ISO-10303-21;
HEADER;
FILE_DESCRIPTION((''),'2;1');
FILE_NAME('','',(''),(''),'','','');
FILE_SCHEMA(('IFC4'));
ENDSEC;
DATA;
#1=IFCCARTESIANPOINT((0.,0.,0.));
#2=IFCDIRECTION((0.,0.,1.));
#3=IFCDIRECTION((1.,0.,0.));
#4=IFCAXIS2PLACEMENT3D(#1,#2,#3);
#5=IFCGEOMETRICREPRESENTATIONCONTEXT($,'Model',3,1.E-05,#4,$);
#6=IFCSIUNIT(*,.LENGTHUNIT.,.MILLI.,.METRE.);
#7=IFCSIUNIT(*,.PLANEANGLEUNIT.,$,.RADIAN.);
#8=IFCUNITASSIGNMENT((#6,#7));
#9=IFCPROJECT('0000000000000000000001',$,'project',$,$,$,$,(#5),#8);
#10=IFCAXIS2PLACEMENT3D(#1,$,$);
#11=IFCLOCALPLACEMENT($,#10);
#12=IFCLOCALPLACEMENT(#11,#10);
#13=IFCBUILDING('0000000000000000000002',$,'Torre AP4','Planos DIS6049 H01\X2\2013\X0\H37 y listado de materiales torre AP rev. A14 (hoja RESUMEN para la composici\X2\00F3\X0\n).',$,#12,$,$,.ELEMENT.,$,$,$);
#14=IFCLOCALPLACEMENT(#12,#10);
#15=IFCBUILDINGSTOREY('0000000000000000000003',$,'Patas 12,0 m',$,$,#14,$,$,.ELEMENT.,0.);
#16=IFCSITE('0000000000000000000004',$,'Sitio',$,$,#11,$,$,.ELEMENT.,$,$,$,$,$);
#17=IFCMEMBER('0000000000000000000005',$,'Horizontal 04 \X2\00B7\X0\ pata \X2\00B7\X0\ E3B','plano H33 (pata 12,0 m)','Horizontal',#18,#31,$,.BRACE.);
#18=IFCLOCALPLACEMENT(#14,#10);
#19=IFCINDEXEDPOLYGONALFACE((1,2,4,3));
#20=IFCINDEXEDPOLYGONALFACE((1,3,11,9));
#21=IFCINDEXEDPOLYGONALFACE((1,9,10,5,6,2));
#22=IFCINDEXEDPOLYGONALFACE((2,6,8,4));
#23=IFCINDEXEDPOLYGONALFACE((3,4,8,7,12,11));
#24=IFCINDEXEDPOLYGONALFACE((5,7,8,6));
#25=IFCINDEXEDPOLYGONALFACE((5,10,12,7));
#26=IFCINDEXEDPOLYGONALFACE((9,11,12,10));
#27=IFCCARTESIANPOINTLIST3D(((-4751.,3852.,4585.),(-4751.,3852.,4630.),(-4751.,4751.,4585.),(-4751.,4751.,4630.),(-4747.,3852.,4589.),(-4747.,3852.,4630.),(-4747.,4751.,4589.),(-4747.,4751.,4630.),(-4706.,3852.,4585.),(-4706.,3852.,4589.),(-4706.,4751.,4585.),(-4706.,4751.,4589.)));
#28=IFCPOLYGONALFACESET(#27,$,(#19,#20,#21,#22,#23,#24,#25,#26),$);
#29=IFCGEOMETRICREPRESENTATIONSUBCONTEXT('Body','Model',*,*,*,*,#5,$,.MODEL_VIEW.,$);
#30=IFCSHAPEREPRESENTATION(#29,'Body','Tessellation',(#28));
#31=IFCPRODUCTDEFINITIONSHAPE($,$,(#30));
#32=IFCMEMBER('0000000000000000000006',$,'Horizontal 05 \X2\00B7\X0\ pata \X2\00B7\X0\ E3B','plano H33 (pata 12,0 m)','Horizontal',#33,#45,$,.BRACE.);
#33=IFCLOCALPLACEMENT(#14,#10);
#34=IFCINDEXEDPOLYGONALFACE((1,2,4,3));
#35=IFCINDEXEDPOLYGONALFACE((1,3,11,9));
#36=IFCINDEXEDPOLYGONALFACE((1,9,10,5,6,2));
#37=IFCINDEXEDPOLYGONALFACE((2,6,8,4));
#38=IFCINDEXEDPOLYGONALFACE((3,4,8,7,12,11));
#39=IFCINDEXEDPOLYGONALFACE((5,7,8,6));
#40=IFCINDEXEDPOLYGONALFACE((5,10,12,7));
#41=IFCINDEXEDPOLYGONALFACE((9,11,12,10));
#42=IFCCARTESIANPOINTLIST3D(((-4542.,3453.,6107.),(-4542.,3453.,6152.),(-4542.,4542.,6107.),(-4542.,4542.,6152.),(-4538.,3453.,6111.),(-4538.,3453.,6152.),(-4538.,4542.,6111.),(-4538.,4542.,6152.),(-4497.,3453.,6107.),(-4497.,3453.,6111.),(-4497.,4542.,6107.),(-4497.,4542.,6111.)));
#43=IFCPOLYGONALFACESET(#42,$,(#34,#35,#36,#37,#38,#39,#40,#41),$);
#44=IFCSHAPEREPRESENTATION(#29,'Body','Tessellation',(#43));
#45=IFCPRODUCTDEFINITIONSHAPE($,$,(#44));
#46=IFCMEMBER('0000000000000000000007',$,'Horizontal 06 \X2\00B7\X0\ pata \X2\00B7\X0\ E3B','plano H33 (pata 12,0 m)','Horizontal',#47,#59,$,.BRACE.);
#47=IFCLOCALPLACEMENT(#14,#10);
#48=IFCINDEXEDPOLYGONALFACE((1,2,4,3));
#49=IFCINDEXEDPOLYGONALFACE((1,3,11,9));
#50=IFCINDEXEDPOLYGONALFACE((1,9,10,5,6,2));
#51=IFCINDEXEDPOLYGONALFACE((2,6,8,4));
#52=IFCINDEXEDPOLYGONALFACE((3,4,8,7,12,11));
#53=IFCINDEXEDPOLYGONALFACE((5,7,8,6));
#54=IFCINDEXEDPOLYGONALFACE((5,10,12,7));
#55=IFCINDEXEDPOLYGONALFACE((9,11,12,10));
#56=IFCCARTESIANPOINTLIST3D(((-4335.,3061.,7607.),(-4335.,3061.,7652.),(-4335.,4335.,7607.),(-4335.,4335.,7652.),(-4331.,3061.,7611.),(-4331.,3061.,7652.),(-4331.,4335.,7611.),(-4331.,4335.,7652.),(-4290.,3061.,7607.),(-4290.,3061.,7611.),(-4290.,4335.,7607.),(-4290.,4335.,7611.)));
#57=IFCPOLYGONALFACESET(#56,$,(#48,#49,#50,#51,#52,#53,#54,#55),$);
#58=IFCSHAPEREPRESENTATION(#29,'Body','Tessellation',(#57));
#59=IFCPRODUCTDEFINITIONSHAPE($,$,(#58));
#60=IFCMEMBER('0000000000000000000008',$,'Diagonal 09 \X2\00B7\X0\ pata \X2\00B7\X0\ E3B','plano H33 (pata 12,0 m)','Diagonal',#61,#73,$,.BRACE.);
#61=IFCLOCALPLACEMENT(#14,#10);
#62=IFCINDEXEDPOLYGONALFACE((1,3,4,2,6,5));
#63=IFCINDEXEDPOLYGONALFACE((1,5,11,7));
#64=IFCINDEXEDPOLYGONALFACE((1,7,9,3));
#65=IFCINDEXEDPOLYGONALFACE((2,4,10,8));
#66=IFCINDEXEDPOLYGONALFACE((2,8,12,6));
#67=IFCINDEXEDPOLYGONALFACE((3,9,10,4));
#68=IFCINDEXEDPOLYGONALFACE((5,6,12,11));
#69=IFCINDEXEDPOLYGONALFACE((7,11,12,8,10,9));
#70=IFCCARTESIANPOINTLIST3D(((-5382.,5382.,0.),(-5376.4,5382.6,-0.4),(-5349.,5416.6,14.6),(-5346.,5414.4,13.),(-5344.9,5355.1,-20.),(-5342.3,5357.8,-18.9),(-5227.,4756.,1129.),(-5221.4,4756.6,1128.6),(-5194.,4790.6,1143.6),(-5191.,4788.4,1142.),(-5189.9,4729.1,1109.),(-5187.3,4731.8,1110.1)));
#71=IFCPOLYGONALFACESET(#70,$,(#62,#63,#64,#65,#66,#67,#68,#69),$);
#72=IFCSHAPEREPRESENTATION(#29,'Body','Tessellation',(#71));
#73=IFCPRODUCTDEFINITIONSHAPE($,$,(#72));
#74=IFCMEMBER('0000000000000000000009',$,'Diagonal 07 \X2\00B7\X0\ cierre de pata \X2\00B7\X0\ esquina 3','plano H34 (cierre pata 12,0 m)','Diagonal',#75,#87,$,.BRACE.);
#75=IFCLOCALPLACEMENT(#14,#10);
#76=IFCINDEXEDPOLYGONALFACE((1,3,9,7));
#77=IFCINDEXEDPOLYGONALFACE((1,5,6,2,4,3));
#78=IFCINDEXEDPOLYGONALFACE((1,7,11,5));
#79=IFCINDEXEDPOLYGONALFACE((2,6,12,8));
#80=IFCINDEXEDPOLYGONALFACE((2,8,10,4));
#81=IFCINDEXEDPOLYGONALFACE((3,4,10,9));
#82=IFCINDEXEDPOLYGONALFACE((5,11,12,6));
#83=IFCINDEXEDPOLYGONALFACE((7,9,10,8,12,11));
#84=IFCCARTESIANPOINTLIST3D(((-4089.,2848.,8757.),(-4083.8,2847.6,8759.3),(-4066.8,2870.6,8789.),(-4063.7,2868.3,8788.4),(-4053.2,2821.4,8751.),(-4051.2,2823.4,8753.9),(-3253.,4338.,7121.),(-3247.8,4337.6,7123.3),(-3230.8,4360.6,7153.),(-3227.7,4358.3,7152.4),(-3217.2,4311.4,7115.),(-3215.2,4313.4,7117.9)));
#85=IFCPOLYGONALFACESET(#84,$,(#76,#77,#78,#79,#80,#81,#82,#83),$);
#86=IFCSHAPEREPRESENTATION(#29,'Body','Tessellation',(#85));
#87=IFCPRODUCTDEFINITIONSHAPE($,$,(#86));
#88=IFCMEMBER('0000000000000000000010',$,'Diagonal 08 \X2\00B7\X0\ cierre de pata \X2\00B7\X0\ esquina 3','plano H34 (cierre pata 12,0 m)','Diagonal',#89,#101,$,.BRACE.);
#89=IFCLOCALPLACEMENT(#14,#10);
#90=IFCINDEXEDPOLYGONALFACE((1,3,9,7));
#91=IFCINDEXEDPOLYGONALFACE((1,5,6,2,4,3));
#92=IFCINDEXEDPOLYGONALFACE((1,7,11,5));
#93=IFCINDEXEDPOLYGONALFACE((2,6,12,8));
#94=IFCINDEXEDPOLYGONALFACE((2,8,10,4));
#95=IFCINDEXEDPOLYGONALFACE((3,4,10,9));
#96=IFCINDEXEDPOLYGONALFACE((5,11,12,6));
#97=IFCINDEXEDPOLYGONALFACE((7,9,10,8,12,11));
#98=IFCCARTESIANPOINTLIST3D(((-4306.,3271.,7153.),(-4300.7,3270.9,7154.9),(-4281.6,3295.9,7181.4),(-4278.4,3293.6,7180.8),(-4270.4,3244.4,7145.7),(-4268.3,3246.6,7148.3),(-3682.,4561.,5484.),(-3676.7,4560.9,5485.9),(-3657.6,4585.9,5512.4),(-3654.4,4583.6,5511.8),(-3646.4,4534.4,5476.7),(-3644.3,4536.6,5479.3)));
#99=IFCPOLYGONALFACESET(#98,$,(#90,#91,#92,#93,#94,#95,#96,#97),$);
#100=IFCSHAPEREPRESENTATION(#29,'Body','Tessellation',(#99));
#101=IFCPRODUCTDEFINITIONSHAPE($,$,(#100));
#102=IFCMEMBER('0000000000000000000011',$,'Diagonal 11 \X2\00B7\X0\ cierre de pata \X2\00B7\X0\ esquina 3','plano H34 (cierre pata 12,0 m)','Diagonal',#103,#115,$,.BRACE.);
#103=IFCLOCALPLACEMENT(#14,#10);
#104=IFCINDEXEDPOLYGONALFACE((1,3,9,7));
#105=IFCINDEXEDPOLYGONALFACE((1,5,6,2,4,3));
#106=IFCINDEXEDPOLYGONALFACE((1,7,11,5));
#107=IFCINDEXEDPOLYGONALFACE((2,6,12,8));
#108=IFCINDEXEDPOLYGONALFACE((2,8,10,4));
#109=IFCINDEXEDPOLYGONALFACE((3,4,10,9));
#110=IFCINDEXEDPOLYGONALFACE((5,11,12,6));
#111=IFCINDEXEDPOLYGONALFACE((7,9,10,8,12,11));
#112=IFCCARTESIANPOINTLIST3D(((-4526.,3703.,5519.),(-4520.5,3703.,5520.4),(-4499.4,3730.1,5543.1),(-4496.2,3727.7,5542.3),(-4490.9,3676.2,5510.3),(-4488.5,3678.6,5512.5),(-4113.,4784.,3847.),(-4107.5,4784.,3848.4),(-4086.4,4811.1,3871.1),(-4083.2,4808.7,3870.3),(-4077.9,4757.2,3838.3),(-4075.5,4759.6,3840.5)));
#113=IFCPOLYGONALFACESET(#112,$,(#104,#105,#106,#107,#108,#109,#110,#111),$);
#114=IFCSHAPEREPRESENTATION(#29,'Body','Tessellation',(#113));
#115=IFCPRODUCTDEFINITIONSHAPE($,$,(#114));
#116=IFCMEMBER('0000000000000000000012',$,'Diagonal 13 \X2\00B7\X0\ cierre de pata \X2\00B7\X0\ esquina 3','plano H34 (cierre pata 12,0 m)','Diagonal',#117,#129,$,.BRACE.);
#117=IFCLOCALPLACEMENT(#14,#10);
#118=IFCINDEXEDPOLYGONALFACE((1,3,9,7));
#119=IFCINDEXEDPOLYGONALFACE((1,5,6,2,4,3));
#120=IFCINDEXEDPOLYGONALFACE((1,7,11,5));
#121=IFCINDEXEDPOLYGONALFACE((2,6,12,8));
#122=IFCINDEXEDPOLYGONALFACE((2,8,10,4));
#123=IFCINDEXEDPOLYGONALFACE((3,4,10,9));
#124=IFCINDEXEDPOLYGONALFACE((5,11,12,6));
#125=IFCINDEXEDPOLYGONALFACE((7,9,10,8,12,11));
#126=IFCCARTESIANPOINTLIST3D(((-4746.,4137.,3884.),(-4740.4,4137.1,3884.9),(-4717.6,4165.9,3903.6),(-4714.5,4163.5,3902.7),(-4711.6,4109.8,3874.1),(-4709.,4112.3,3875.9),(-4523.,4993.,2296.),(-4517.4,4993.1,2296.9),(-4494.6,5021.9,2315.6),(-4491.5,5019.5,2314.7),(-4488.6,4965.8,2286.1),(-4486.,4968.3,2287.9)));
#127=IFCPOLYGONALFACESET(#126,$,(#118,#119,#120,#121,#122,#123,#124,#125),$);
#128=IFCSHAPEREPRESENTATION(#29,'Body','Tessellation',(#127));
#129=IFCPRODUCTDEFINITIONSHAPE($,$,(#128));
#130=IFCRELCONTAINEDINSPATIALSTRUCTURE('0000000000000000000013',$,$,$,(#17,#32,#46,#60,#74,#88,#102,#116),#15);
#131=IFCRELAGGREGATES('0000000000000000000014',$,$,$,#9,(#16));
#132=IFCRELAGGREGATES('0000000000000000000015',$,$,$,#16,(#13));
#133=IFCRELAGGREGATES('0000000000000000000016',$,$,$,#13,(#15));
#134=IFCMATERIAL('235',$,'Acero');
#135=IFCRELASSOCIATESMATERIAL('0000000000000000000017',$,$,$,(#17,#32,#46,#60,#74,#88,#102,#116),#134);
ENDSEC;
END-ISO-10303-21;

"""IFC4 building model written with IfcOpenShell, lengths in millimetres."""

from ifc_helpers import new_model, si_unit, frame, frame_2d, origin, origin_with_axes, place, context, subcontext, project, spatial, l_section, extrude, material, element, save


model = new_model("IFC4")

# Units and contexts
model_context = context("Model", 3, precision=1e-05, world=origin_with_axes())
body_context = subcontext(model_context, "Body", "Model", "MODEL_VIEW")
ifc_project = project(units=[si_unit("LENGTHUNIT", "METRE", prefix="MILLI"), si_unit("PLANEANGLEUNIT", "RADIAN")], contexts=[model_context])

# Site, building, storey
site_placement = place(None, origin())
site = spatial("IfcSite", under=ifc_project, at=site_placement, Name="Sitio", CompositionType="ELEMENT")
building_placement = place(site_placement, origin())
building = spatial("IfcBuilding", under=site, at=building_placement, Name="Torre AP4", Description="Planos DIS6049 H01–H37 y listado de materiales torre AP rev. A14 (hoja RESUMEN para la composición).", CompositionType="ELEMENT")
storey_placement = place(building_placement, origin())
storey = spatial("IfcBuildingStorey", under=building, at=storey_placement, Name="Patas 12,0 m", CompositionType="ELEMENT", Elevation=0.0)

# Members
ifc_material_1 = material(Name="235", Category="Acero")
member_1_placement = place(storey_placement, frame((-4751.0, 4751.0, 4585.0), z_axis=(0.0, -1.0, 0.0), x_axis=(1.0, 0.0, 0.0)))
element("IfcMember", 1, at=member_1_placement, inside=storey, material=ifc_material_1, Name="Horizontal 04 · pata · E3B", Description="plano H33 (pata 12,0 m)", ObjectType="Horizontal", PredefinedType="BRACE", context=body_context, shape_type="SweptSolid", body=[
    extrude(l_section(Depth=45.0, Width=45.0, Thickness=4.0, at=frame_2d((22.5, 22.5))), None, (0.0, 0.0, 1.0), 899.0),
])
member_2_placement = place(storey_placement, frame((-4542.0, 4542.0, 6107.0), z_axis=(0.0, -1.0, 0.0), x_axis=(1.0, 0.0, 0.0)))
element("IfcMember", 2, at=member_2_placement, inside=storey, material=ifc_material_1, Name="Horizontal 05 · pata · E3B", Description="plano H33 (pata 12,0 m)", ObjectType="Horizontal", PredefinedType="BRACE", context=body_context, shape_type="SweptSolid", body=[
    extrude(l_section(Depth=45.0, Width=45.0, Thickness=4.0, at=frame_2d((22.5, 22.5))), None, (0.0, 0.0, 1.0), 1089.0),
])
member_3_placement = place(storey_placement, frame((-4335.0, 4335.0, 7607.0), z_axis=(0.0, -1.0, 0.0), x_axis=(1.0, 0.0, 0.0)))
element("IfcMember", 3, at=member_3_placement, inside=storey, material=ifc_material_1, Name="Horizontal 06 · pata · E3B", Description="plano H33 (pata 12,0 m)", ObjectType="Horizontal", PredefinedType="BRACE", context=body_context, shape_type="SweptSolid", body=[
    extrude(l_section(Depth=45.0, Width=45.0, Thickness=4.0, at=frame_2d((22.5, 22.5))), None, (0.0, 0.0, 1.0), 1274.0),
])
member_4_placement = place(storey_placement, frame((-5382.0, 5382.0, 0.0), z_axis=(0.119212, -0.481461, 0.868322), x_axis=(0.741182, -0.53876, -0.400484)))
element("IfcMember", 4, at=member_4_placement, inside=storey, material=ifc_material_1, Name="Diagonal 09 · pata · E3B", Description="plano H33 (pata 12,0 m)", ObjectType="Diagonal", PredefinedType="BRACE", context=body_context, shape_type="SweptSolid", body=[
    extrude(l_section(Depth=50.0, Width=50.0, Thickness=4.0, at=frame_2d((25.0, 25.0))), None, (0.0, 0.0, 1.0), 1300.2),
])
member_5_placement = place(storey_placement, frame((-3253.0, 4338.0, 7121.0), z_axis=(-0.353417, -0.629894, 0.691615), x_axis=(0.795293, -0.591591, -0.1324)))
element("IfcMember", 5, at=member_5_placement, inside=storey, material=ifc_material_1, Name="Diagonal 07 · cierre de pata · esquina 3", Description="plano H34 (cierre pata 12,0 m)", ObjectType="Diagonal", PredefinedType="BRACE", context=body_context, shape_type="SweptSolid", body=[
    extrude(l_section(Depth=45.0, Width=45.0, Thickness=4.0, at=frame_2d((22.5, 22.5))), None, (0.0, 0.0, 1.0), 2365.5),
])
member_6_placement = place(storey_placement, frame((-3682.0, 4561.0, 5484.0), z_axis=(-0.283665, -0.586422, 0.758712), x_axis=(0.790335, -0.591049, -0.161345)))
element("IfcMember", 6, at=member_6_placement, inside=storey, material=ifc_material_1, Name="Diagonal 08 · cierre de pata · esquina 3", Description="plano H34 (cierre pata 12,0 m)", ObjectType="Diagonal", PredefinedType="BRACE", context=body_context, shape_type="SweptSolid", body=[
    extrude(l_section(Depth=45.0, Width=45.0, Thickness=4.0, at=frame_2d((22.5, 22.5))), None, (0.0, 0.0, 1.0), 2199.8),
])
member_7_placement = place(storey_placement, frame((-4113.0, 4784.0, 3847.0), z_axis=(-0.203108, -0.531622, 0.822268), x_axis=(0.780084, -0.595404, -0.192259)))
element("IfcMember", 7, at=member_7_placement, inside=storey, material=ifc_material_1, Name="Diagonal 11 · cierre de pata · esquina 3", Description="plano H34 (cierre pata 12,0 m)", ObjectType="Diagonal", PredefinedType="BRACE", context=body_context, shape_type="SweptSolid", body=[
    extrude(l_section(Depth=45.0, Width=45.0, Thickness=4.0, at=frame_2d((22.5, 22.5))), None, (0.0, 0.0, 1.0), 2033.4),
])
member_8_placement = place(storey_placement, frame((-4523.0, 4993.0, 2296.0), z_axis=(-0.122679, -0.470912, 0.873608), x_axis=(0.765194, -0.605441, -0.218904)))
element("IfcMember", 8, at=member_8_placement, inside=storey, material=ifc_material_1, Name="Diagonal 13 · cierre de pata · esquina 3", Description="plano H34 (cierre pata 12,0 m)", ObjectType="Diagonal", PredefinedType="BRACE", context=body_context, shape_type="SweptSolid", body=[
    extrude(l_section(Depth=45.0, Width=45.0, Thickness=4.0, at=frame_2d((22.5, 22.5))), None, (0.0, 0.0, 1.0), 1817.7),
])

save(model, "model.ifc")
